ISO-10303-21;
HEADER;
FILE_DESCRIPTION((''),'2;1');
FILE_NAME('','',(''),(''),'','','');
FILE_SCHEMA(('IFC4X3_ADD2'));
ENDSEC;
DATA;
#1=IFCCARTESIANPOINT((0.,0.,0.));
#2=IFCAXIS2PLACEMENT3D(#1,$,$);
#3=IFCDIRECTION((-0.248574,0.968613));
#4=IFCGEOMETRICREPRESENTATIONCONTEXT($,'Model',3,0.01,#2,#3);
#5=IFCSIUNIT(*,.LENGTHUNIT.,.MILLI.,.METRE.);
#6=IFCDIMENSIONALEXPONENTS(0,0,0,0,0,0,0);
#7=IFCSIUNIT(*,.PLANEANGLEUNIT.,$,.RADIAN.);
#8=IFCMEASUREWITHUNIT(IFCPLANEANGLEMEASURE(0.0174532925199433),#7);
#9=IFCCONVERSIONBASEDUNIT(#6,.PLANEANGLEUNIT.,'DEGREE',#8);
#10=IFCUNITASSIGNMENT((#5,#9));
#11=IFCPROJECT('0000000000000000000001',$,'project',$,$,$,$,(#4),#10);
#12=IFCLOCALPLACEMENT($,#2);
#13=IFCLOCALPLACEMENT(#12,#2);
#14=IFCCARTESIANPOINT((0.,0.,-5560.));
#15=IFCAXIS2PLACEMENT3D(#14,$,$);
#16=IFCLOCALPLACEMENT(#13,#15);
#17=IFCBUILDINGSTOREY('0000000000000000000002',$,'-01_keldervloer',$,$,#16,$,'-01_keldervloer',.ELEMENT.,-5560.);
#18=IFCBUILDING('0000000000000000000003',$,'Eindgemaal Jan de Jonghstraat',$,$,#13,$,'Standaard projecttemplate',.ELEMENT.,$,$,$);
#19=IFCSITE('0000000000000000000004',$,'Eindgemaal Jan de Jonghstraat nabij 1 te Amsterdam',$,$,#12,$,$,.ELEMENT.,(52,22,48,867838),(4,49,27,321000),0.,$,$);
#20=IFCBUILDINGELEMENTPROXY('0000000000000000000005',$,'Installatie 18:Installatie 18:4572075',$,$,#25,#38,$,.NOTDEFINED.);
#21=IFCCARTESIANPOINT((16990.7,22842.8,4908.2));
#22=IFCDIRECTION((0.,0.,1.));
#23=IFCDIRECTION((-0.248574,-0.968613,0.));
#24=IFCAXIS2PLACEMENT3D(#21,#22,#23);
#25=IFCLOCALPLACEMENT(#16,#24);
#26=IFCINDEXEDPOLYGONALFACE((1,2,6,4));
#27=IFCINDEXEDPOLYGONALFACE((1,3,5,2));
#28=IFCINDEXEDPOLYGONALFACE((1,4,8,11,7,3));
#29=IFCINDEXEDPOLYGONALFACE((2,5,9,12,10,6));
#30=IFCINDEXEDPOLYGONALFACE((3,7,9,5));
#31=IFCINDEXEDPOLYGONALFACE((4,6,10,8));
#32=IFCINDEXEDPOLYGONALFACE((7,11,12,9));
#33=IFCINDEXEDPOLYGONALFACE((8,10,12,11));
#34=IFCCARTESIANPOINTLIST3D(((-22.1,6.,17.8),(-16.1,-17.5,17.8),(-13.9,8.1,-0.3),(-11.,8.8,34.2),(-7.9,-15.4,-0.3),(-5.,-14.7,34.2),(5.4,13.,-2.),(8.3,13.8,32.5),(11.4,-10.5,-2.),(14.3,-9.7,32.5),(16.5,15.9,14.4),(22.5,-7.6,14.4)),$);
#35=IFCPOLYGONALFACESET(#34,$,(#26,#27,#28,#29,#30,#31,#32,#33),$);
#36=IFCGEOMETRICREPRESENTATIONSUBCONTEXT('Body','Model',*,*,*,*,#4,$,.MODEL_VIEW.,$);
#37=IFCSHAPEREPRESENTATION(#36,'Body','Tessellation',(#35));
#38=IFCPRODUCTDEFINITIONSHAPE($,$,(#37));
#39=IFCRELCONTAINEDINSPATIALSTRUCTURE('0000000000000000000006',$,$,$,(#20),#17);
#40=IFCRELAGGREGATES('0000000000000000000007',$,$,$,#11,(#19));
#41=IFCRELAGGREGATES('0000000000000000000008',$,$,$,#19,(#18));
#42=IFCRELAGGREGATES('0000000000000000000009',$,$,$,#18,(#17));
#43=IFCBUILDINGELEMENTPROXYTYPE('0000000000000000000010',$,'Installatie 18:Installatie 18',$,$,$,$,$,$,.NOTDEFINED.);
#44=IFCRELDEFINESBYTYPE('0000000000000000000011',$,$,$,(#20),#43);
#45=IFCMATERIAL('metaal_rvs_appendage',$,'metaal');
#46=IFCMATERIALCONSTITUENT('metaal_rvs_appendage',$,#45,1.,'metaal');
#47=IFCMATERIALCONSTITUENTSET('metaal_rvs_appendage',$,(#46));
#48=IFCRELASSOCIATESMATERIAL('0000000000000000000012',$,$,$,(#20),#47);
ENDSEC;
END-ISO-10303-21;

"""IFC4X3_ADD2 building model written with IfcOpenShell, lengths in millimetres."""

from ifc_helpers import new_model, entity, si_unit, converted_unit, direction, frame, origin, place, context, subcontext, project, spatial, polyline, outline, extrude, source, transform, mapped, material, constituent, constituent_set, type_object, type_shapes, element, save


model = new_model("IFC4X3_ADD2")

# Units and contexts
model_context = context("Model", 3, precision=0.01, world=origin(), true_north=direction((-0.248574, 0.968613)))
body_context = subcontext(model_context, "Body", "Model", "MODEL_VIEW")
ifc_project = project(units=[si_unit("LENGTHUNIT", "METRE", prefix="MILLI"), converted_unit("PLANEANGLEUNIT", "DEGREE", entity("IfcPlaneAngleMeasure", 0.0174532925199433), si_unit("PLANEANGLEUNIT", "RADIAN"), dimensions=[0, 0, 0, 0, 0, 0, 0])], contexts=[model_context])

# Site, building, storey
site_placement = place(None, origin())
site = spatial("IfcSite", under=ifc_project, at=site_placement, Name="Eindgemaal Jan de Jonghstraat nabij 1 te Amsterdam", CompositionType="ELEMENT", RefLatitude=(52, 22, 48, 867838), RefLongitude=(4, 49, 27, 321000), RefElevation=0.0)
building_placement = place(site_placement, origin())
building = spatial("IfcBuilding", under=site, at=building_placement, Name="Eindgemaal Jan de Jonghstraat", LongName="Standaard projecttemplate", CompositionType="ELEMENT")
storey_placement = place(building_placement, frame((0.0, 0.0, -5560.0)))
storey = spatial("IfcBuildingStorey", under=building, at=storey_placement, Name="-01_keldervloer", LongName="-01_keldervloer", CompositionType="ELEMENT", Elevation=-5560.0)

# Building element proxy
ifc_material_1 = material(Name="metaal_rvs_appendage", Category="metaal")
ifc_constituent_1 = constituent(ifc_material_1, Name="metaal_rvs_appendage", Category="metaal", fraction=1.0)
ifc_constituent_set_1 = constituent_set(constituents=[ifc_constituent_1], Name="metaal_rvs_appendage")
building_element_proxy_type_1 = type_object("IfcBuildingElementProxyType", Name="Installatie 18:Installatie 18", PredefinedType="NOTDEFINED")
shared_shape_1 = source(origin(), body_context, "Body", "SweptSolid", [
    extrude(outline(polyline([(-10.0, -17.3), (10.0, -17.3), (20.0, 0.0), (10.0, 17.3), (-10.0, 17.3), (-20.0, 0.0), (-10.0, -17.3)])), frame((3.2, -12.6, 16.1), z_axis=(-0.248574, 0.968613, 0.0), x_axis=(0.409353, 0.105052, -0.906308)), (0.0, 0.0, 1.0), 24.3),
])
type_shapes(building_element_proxy_type_1, [shared_shape_1])
for number, where, z_axis, x_axis, name in (
    (1, (16990.7, 22842.8, 4908.2), (0.0, 0.0, 1.0), (-0.248574, -0.968613, 0.0), "Installatie 18:Installatie 18:4572075"),
):
    element("IfcBuildingElementProxy", number, at=place(storey_placement, frame(where, z_axis=z_axis, x_axis=x_axis)), inside=storey, type_object=building_element_proxy_type_1, material=ifc_constituent_set_1, Name=name, PredefinedType="NOTDEFINED", context=body_context, shape_type="MappedRepresentation", body=[
        mapped(shared_shape_1, transform((0.0, 0.0, 0.0), scale=1.0)),
    ])

save(model, "model.ifc")
